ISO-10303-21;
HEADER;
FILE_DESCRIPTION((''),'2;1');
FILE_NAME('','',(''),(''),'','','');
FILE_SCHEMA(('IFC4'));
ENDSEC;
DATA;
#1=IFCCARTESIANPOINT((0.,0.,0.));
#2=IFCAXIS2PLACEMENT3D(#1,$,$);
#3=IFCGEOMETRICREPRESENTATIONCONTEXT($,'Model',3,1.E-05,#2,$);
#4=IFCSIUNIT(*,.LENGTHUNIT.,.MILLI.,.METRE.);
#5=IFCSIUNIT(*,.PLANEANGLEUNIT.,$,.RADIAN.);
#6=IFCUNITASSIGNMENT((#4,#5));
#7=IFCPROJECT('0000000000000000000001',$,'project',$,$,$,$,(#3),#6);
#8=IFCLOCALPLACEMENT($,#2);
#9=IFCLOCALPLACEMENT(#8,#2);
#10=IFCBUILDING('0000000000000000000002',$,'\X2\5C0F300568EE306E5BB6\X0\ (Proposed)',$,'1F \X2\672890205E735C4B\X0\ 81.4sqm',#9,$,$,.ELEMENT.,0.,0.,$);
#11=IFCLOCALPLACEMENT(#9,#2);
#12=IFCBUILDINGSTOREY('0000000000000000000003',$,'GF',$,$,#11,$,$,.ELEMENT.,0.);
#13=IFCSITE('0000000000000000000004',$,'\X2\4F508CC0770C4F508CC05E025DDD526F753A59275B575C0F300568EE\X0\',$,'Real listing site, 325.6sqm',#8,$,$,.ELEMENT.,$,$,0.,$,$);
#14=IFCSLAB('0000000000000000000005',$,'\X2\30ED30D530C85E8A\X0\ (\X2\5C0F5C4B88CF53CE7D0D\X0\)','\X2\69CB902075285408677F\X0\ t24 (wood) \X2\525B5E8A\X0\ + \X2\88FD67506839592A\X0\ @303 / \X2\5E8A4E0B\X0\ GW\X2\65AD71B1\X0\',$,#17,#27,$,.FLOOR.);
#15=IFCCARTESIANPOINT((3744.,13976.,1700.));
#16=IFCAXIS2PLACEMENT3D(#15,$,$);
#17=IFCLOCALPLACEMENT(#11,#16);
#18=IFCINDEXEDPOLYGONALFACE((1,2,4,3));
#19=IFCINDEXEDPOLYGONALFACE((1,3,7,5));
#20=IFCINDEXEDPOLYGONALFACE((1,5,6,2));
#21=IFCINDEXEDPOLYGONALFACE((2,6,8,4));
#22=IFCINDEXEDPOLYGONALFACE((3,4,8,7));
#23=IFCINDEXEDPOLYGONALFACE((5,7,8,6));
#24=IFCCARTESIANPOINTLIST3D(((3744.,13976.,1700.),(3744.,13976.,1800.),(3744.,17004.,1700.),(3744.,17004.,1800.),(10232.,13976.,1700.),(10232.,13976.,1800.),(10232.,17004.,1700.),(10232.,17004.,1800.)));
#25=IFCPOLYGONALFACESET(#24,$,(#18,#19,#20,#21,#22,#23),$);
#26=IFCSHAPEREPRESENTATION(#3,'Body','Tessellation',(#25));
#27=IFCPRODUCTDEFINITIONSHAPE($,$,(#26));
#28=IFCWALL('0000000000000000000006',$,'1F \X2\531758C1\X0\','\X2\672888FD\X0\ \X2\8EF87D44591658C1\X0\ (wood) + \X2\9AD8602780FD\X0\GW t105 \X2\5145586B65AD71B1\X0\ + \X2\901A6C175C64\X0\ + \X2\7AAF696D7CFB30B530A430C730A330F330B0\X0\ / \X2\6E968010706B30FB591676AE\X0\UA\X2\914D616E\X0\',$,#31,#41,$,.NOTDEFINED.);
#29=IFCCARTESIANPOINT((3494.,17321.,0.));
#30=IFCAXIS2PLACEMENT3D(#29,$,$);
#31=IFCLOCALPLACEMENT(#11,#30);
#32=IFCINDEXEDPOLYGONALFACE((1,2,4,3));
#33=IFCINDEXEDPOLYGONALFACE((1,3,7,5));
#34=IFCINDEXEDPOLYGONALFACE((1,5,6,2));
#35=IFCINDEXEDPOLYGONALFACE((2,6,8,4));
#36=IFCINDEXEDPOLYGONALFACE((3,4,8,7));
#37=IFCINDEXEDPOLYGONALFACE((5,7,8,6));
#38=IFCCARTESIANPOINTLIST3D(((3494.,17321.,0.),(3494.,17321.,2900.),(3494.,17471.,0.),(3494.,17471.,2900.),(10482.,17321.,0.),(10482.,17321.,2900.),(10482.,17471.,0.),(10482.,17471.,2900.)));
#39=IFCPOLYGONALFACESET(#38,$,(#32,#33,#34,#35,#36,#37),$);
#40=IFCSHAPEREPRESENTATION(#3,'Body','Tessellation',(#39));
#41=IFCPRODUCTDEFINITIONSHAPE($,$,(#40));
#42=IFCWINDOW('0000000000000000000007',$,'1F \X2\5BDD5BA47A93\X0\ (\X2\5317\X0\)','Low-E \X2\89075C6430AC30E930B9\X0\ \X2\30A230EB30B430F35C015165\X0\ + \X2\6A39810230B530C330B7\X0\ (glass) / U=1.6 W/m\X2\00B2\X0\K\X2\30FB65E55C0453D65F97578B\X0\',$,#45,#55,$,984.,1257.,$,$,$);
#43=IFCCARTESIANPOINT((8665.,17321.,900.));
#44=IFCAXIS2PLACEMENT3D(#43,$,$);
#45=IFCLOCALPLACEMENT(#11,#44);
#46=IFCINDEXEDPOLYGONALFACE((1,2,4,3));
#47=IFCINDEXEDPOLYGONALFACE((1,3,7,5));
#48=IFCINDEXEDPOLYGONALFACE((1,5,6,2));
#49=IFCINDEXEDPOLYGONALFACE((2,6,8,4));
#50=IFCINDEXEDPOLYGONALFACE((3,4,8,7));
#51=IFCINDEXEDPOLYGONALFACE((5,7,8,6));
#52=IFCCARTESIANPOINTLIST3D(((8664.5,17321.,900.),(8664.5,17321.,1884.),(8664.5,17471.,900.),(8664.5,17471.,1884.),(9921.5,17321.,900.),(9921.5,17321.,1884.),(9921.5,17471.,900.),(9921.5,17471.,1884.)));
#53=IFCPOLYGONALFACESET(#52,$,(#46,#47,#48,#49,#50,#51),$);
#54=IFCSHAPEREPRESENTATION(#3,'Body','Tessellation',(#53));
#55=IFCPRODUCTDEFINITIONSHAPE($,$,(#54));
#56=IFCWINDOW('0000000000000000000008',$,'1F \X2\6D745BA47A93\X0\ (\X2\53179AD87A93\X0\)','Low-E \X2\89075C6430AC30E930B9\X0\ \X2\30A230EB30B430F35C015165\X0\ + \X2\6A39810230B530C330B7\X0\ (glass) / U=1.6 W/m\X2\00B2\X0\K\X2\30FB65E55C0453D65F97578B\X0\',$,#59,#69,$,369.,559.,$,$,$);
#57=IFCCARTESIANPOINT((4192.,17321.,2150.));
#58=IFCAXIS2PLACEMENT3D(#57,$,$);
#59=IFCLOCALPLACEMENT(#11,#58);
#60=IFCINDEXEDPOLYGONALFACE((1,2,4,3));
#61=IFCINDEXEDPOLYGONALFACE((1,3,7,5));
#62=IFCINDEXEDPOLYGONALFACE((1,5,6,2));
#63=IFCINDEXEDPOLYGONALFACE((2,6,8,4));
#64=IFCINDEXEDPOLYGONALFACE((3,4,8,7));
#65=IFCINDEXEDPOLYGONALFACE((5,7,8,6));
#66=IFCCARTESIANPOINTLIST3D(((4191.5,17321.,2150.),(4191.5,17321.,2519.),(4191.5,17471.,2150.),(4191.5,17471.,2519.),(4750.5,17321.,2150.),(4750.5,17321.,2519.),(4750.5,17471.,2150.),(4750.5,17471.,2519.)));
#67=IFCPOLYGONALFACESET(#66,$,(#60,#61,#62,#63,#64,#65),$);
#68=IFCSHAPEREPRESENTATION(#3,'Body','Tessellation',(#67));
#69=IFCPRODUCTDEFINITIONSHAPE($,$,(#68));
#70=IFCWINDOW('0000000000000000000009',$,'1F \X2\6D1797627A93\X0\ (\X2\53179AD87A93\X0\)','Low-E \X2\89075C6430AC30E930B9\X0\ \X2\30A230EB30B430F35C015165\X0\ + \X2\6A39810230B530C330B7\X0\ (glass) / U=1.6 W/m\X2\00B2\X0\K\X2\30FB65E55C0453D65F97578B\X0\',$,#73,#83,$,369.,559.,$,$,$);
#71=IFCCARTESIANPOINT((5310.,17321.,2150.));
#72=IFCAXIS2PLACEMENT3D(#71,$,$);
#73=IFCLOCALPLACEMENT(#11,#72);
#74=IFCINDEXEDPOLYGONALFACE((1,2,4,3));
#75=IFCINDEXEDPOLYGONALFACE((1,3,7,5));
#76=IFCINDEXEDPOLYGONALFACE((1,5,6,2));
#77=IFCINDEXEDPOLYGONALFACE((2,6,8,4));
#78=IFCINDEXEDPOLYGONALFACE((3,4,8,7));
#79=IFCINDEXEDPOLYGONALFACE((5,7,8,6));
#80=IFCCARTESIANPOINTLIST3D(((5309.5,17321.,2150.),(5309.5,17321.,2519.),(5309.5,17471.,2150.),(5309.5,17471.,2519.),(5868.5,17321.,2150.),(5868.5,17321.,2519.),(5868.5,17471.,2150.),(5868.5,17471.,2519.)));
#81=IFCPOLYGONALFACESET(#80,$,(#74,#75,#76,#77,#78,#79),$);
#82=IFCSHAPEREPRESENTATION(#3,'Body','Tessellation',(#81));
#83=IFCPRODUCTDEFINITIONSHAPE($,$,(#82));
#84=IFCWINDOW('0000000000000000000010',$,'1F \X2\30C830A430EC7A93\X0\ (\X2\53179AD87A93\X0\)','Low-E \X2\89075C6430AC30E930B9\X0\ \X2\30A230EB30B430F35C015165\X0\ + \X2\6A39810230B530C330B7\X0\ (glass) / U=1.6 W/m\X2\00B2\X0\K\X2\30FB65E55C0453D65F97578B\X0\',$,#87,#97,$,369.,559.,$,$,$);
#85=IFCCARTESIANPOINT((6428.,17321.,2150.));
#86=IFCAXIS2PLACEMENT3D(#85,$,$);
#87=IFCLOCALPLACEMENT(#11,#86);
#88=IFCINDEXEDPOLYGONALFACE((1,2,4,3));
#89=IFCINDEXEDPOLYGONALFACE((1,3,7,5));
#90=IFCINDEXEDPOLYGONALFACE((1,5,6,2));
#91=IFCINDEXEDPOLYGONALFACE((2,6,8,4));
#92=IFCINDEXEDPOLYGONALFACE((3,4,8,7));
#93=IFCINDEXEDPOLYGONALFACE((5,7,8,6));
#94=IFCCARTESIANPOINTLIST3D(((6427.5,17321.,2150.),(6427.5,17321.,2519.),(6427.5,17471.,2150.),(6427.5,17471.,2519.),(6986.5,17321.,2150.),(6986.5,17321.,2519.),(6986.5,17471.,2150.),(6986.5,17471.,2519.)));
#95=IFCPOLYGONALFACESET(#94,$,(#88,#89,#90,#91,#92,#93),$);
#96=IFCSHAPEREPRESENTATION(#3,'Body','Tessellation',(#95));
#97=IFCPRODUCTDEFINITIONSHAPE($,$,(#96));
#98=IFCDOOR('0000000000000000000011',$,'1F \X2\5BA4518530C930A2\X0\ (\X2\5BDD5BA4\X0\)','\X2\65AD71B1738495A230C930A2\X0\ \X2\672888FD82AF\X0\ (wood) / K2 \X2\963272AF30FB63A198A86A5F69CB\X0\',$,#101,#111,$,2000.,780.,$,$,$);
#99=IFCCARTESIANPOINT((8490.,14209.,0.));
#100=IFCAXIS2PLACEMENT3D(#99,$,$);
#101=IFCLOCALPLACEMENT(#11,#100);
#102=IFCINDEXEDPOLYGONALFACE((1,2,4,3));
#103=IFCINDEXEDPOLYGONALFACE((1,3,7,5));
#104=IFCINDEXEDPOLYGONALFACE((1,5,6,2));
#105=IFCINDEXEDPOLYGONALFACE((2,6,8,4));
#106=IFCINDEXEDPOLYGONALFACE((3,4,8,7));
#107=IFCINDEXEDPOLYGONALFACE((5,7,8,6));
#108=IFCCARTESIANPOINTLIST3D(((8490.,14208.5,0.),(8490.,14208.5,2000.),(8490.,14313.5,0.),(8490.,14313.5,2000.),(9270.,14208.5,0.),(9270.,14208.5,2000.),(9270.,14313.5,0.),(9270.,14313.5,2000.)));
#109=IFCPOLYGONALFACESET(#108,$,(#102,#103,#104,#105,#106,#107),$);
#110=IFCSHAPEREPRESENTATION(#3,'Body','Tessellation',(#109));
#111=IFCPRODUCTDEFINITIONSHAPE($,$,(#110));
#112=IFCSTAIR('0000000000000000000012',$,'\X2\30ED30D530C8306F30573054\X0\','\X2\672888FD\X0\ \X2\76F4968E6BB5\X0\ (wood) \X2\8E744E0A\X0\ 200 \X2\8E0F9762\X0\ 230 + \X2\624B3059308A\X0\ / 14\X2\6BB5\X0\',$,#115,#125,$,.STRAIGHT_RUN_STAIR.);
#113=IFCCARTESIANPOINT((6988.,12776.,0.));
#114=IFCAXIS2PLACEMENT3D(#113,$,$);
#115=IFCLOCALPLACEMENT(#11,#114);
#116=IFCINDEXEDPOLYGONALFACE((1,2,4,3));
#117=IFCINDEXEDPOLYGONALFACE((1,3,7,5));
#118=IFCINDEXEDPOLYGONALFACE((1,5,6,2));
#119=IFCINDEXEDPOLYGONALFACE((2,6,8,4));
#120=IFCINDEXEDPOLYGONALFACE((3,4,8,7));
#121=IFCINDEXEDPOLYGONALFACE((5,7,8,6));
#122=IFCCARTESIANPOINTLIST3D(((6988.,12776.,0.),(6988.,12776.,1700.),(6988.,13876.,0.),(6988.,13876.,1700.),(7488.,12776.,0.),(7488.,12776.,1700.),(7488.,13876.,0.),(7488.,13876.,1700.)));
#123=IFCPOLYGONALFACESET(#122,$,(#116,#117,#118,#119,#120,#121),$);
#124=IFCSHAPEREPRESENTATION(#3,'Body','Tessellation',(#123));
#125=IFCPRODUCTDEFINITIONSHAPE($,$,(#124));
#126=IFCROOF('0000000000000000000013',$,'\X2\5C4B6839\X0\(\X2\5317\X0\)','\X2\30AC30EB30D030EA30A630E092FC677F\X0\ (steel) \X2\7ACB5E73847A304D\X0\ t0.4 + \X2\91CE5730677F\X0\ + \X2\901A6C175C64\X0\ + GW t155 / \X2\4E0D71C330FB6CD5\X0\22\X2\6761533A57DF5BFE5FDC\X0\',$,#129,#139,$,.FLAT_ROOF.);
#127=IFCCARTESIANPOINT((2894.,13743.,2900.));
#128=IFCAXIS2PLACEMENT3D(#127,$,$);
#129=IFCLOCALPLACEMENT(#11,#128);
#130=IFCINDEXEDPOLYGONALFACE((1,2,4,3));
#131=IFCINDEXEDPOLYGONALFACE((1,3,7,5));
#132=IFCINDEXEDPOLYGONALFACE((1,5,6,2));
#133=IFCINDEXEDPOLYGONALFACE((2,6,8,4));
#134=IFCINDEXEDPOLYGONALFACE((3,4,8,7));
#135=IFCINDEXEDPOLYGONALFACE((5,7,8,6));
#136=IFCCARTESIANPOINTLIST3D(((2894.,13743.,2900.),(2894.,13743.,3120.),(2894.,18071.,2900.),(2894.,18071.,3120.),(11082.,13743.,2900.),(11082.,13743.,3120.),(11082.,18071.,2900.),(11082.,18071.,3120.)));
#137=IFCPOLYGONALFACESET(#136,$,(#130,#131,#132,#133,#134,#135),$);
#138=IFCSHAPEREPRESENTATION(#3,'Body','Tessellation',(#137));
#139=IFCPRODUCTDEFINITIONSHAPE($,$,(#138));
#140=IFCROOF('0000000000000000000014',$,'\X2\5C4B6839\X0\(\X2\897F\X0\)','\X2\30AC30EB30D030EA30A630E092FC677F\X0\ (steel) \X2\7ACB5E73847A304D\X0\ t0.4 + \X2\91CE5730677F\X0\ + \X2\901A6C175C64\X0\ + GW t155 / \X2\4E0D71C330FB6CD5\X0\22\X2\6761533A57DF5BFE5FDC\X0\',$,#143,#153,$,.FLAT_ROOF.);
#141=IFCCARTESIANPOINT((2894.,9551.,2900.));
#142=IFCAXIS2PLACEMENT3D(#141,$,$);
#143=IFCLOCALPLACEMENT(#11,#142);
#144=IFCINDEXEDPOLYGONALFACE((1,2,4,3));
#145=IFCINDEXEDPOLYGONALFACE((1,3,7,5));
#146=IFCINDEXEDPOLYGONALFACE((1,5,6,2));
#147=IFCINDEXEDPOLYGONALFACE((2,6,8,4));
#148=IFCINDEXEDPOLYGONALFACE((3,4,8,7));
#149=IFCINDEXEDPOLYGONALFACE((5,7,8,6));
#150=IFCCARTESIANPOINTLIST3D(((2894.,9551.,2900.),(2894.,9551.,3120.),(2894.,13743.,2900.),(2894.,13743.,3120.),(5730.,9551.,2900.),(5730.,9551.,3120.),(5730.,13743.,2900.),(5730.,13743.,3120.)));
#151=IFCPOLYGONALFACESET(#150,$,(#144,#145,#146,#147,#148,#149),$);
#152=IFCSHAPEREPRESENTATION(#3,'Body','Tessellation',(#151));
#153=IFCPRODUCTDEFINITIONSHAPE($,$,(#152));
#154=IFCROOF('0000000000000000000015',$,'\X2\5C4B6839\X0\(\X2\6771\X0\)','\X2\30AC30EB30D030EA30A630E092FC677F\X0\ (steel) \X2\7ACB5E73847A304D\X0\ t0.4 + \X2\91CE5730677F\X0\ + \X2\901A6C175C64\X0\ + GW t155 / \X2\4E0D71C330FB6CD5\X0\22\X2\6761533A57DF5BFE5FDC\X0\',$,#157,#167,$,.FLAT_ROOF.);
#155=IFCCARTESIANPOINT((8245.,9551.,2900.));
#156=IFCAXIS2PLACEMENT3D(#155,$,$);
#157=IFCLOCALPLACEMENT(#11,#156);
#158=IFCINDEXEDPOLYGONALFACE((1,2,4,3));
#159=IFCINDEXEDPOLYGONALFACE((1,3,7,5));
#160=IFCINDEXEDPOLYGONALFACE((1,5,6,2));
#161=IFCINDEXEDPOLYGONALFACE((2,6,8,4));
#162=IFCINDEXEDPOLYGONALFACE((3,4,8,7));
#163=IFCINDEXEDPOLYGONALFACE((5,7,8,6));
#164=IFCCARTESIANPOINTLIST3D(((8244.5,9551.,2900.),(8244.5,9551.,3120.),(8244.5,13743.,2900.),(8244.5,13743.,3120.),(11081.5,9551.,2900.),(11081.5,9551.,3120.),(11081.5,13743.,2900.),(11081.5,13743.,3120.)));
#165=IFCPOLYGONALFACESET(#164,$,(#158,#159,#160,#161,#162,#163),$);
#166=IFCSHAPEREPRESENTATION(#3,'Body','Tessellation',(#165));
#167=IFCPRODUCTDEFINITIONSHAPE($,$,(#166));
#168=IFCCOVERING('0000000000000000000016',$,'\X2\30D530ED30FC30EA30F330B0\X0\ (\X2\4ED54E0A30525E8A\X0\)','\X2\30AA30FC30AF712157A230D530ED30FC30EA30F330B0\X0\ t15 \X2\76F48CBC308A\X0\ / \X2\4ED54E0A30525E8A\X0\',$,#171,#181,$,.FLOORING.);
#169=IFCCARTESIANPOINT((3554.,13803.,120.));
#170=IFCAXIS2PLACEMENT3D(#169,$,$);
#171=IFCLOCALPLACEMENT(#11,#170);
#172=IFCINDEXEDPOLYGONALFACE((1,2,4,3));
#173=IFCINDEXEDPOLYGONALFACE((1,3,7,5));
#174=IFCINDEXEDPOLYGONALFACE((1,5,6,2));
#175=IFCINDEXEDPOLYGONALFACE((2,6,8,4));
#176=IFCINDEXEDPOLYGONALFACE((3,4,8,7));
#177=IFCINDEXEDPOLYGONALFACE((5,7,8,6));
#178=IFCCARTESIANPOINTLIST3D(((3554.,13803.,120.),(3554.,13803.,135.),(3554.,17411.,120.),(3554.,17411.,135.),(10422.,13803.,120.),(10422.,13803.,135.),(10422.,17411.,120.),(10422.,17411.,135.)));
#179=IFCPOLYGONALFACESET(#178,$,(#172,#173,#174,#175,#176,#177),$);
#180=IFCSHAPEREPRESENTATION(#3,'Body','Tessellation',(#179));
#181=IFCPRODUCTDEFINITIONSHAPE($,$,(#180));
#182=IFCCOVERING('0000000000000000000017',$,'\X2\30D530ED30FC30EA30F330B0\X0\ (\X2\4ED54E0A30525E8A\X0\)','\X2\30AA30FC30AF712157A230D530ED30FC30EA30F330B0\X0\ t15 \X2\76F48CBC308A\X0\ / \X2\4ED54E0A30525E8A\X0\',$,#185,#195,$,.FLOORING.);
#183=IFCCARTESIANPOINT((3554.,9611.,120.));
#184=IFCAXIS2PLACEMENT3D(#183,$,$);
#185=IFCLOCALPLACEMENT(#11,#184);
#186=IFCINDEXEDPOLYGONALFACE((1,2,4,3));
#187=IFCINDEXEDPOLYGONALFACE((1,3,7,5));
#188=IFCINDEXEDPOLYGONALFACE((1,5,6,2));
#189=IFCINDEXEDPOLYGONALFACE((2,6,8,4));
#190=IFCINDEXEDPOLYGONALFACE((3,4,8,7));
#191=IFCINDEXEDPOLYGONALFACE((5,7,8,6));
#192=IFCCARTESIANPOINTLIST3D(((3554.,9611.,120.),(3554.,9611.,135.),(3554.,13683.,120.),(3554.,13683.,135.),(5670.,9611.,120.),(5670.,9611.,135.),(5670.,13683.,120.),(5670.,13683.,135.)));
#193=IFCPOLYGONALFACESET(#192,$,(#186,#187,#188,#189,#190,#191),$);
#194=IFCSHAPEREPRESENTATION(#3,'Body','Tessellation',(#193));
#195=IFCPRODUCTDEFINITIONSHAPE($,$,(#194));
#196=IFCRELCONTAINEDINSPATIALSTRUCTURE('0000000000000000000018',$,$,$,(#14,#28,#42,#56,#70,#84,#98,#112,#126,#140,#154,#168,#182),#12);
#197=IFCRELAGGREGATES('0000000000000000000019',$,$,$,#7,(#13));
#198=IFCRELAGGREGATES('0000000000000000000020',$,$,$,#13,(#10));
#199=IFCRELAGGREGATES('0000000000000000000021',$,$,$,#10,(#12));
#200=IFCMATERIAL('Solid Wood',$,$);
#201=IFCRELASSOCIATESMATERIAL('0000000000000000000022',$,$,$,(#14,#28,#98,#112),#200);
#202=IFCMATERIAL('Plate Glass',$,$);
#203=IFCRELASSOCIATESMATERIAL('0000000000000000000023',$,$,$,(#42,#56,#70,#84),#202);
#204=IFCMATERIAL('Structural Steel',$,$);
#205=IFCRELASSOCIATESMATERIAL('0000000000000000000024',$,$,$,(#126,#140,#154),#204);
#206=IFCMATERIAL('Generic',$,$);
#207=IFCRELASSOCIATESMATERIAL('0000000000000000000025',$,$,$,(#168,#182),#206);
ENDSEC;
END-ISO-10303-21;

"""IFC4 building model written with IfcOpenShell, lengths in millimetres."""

from ifc_helpers import new_model, si_unit, frame, frame_2d, origin, place, context, project, spatial, rectangle, extrude, material, element, fill, save


model = new_model("IFC4")

# Units and contexts
model_context = context("Model", 3, precision=1e-05, world=origin())
ifc_project = project(units=[si_unit("LENGTHUNIT", "METRE", prefix="MILLI"), si_unit("PLANEANGLEUNIT", "RADIAN")], contexts=[model_context])

# Site, building, storey
site_placement = place(None, origin())
site = spatial("IfcSite", under=ifc_project, at=site_placement, Name="佐賀県佐賀市川副町大字小々森", ObjectType="Real listing site, 325.6sqm", CompositionType="ELEMENT", RefElevation=0.0)
building_placement = place(site_placement, origin())
building = spatial("IfcBuilding", under=site, at=building_placement, Name="小々森の家 (Proposed)", ObjectType="1F 木造平屋 81.4sqm", CompositionType="ELEMENT", ElevationOfRefHeight=0.0, ElevationOfTerrain=0.0)
storey_placement = place(building_placement, origin())
storey = spatial("IfcBuildingStorey", under=building, at=storey_placement, Name="GF", CompositionType="ELEMENT", Elevation=0.0)

# Slab
ifc_material_1 = material(Name="Solid Wood")
slab_1_placement = place(storey_placement, frame((3744.0, 13976.0, 1700.0)))
element("IfcSlab", 1, at=slab_1_placement, inside=storey, material=ifc_material_1, Name="ロフト床 (小屋裏収納)", Description="構造用合板 t24 (wood) 剛床 + 製材根太 @303 / 床下 GW断熱", PredefinedType="FLOOR", context=model_context, shape_type="SweptSolid", body=[
    extrude(rectangle(XDim=6488.0, YDim=3028.0, at=frame_2d((3244.0, 1514.0))), frame((3744.0, 13976.0, 1700.0)), (0.0, 0.0, 1.0), 100.0),
])

# Wall, openings, windows
wall_1_placement = place(storey_placement, frame((3494.0, 17321.0, 0.0)))
wall_1 = element("IfcWall", 2, at=wall_1_placement, inside=storey, material=ifc_material_1, Name="1F 北壁", Description="木製 軸組外壁 (wood) + 高性能GW t105 充填断熱 + 通気層 + 窯業系サイディング / 準耐火・外皮UA配慮", PredefinedType="NOTDEFINED", context=model_context, shape_type="SweptSolid", body=[
    extrude(rectangle(XDim=6988.0, YDim=150.0, at=frame_2d((3494.0, 75.0))), frame((3494.0, 17321.0, 0.0)), (0.0, 0.0, 1.0), 2900.0),
])
opening_1_placement = place(storey_placement, frame((8665.0, 17321.0, 900.0)))
opening_1 = element("IfcOpeningElement", 3, at=opening_1_placement, cuts=wall_1, PredefinedType="NOTDEFINED", context=model_context, shape_type="SweptSolid", body=[
    extrude(rectangle(XDim=1257.0, YDim=150.0, at=frame_2d((628.0, 75.0))), frame((8665.0, 17321.0, 900.0)), (0.0, 0.0, 1.0), 984.0),
])
opening_2_placement = place(storey_placement, frame((4192.0, 17321.0, 2150.0)))
opening_2 = element("IfcOpeningElement", 4, at=opening_2_placement, cuts=wall_1, PredefinedType="NOTDEFINED", context=model_context, shape_type="SweptSolid", body=[
    extrude(rectangle(XDim=559.0, YDim=150.0, at=frame_2d((279.0, 75.0))), frame((4192.0, 17321.0, 2150.0)), (0.0, 0.0, 1.0), 369.0),
])
opening_3_placement = place(storey_placement, frame((5310.0, 17321.0, 2150.0)))
opening_3 = element("IfcOpeningElement", 5, at=opening_3_placement, cuts=wall_1, PredefinedType="NOTDEFINED", context=model_context, shape_type="SweptSolid", body=[
    extrude(rectangle(XDim=559.0, YDim=150.0, at=frame_2d((279.0, 75.0))), frame((5310.0, 17321.0, 2150.0)), (0.0, 0.0, 1.0), 369.0),
])
opening_4_placement = place(storey_placement, frame((6428.0, 17321.0, 2150.0)))
opening_4 = element("IfcOpeningElement", 6, at=opening_4_placement, cuts=wall_1, PredefinedType="NOTDEFINED", context=model_context, shape_type="SweptSolid", body=[
    extrude(rectangle(XDim=559.0, YDim=150.0, at=frame_2d((279.0, 75.0))), frame((6428.0, 17321.0, 2150.0)), (0.0, 0.0, 1.0), 369.0),
])
ifc_material_2 = material(Name="Plate Glass")
window_1_placement = place(storey_placement, frame((8665.0, 17321.0, 900.0)))
window_1 = element("IfcWindow", 7, at=window_1_placement, inside=storey, material=ifc_material_2, Name="1F 寝室窓 (北)", Description="Low-E 複層ガラス アルゴン封入 + 樹脂サッシ (glass) / U=1.6 W/m²K・日射取得型", OverallHeight=984.0, OverallWidth=1257.0, context=model_context, shape_type="SweptSolid", body=[
    extrude(rectangle(XDim=1257.0, YDim=150.0, at=frame_2d((628.0, 75.0))), frame((8665.0, 17321.0, 900.0)), (0.0, 0.0, 1.0), 984.0),
])
fill(opening_1, window_1)
window_2_placement = place(storey_placement, frame((4192.0, 17321.0, 2150.0)))
window_2 = element("IfcWindow", 8, at=window_2_placement, inside=storey, material=ifc_material_2, Name="1F 浴室窓 (北高窓)", Description="Low-E 複層ガラス アルゴン封入 + 樹脂サッシ (glass) / U=1.6 W/m²K・日射取得型", OverallHeight=369.0, OverallWidth=559.0, context=model_context, shape_type="SweptSolid", body=[
    extrude(rectangle(XDim=559.0, YDim=150.0, at=frame_2d((279.0, 75.0))), frame((4192.0, 17321.0, 2150.0)), (0.0, 0.0, 1.0), 369.0),
])
fill(opening_2, window_2)
window_3_placement = place(storey_placement, frame((5310.0, 17321.0, 2150.0)))
window_3 = element("IfcWindow", 9, at=window_3_placement, inside=storey, material=ifc_material_2, Name="1F 洗面窓 (北高窓)", Description="Low-E 複層ガラス アルゴン封入 + 樹脂サッシ (glass) / U=1.6 W/m²K・日射取得型", OverallHeight=369.0, OverallWidth=559.0, context=model_context, shape_type="SweptSolid", body=[
    extrude(rectangle(XDim=559.0, YDim=150.0, at=frame_2d((279.0, 75.0))), frame((5310.0, 17321.0, 2150.0)), (0.0, 0.0, 1.0), 369.0),
])
fill(opening_3, window_3)
window_4_placement = place(storey_placement, frame((6428.0, 17321.0, 2150.0)))
window_4 = element("IfcWindow", 10, at=window_4_placement, inside=storey, material=ifc_material_2, Name="1F トイレ窓 (北高窓)", Description="Low-E 複層ガラス アルゴン封入 + 樹脂サッシ (glass) / U=1.6 W/m²K・日射取得型", OverallHeight=369.0, OverallWidth=559.0, context=model_context, shape_type="SweptSolid", body=[
    extrude(rectangle(XDim=559.0, YDim=150.0, at=frame_2d((279.0, 75.0))), frame((6428.0, 17321.0, 2150.0)), (0.0, 0.0, 1.0), 369.0),
])
fill(opening_4, window_4)

# Door
door_1_placement = place(storey_placement, frame((8490.0, 14209.0, 0.0)))
element("IfcDoor", 11, at=door_1_placement, inside=storey, material=ifc_material_1, Name="1F 室内ドア (寝室)", Description="断熱玄関ドア 木製芯 (wood) / K2 防犯・採風機構", OverallHeight=2000.0, OverallWidth=780.0, context=model_context, shape_type="SweptSolid", body=[
    extrude(rectangle(XDim=780.0, YDim=105.0, at=frame_2d((390.0, 52.0))), frame((8490.0, 14209.0, 0.0)), (0.0, 0.0, 1.0), 2000.0),
])

# Stair
stair_placement = place(storey_placement, frame((6988.0, 12776.0, 0.0)))
element("IfcStair", 12, at=stair_placement, inside=storey, material=ifc_material_1, Name="ロフトはしご", Description="木製 直階段 (wood) 蹴上 200 踏面 230 + 手すり / 14段", PredefinedType="STRAIGHT_RUN_STAIR", context=model_context, shape_type="SweptSolid", body=[
    extrude(rectangle(XDim=500.0, YDim=1100.0, at=frame_2d((250.0, 550.0))), frame((6988.0, 12776.0, 0.0)), (0.0, 0.0, 1.0), 1700.0),
])

# Roofs
ifc_material_3 = material(Name="Structural Steel")
roof_1_placement = place(storey_placement, frame((2894.0, 13743.0, 2900.0)))
element("IfcRoof", 13, at=roof_1_placement, inside=storey, material=ifc_material_3, Name="屋根(北)", Description="ガルバリウム鋼板 (steel) 立平葺き t0.4 + 野地板 + 通気層 + GW t155 / 不燃・法22条区域対応", PredefinedType="FLAT_ROOF", context=model_context, shape_type="SweptSolid", body=[
    extrude(rectangle(XDim=8188.0, YDim=4328.0, at=frame_2d((4094.0, 2164.0))), frame((2894.0, 13743.0, 2900.0)), (0.0, 0.0, 1.0), 220.0),
])
roof_2_placement = place(storey_placement, frame((2894.0, 9551.0, 2900.0)))
element("IfcRoof", 14, at=roof_2_placement, inside=storey, material=ifc_material_3, Name="屋根(西)", Description="ガルバリウム鋼板 (steel) 立平葺き t0.4 + 野地板 + 通気層 + GW t155 / 不燃・法22条区域対応", PredefinedType="FLAT_ROOF", context=model_context, shape_type="SweptSolid", body=[
    extrude(rectangle(XDim=2836.0, YDim=4192.0, at=frame_2d((1418.0, 2096.0))), frame((2894.0, 9551.0, 2900.0)), (0.0, 0.0, 1.0), 220.0),
])
roof_3_placement = place(storey_placement, frame((8245.0, 9551.0, 2900.0)))
element("IfcRoof", 15, at=roof_3_placement, inside=storey, material=ifc_material_3, Name="屋根(東)", Description="ガルバリウム鋼板 (steel) 立平葺き t0.4 + 野地板 + 通気層 + GW t155 / 不燃・法22条区域対応", PredefinedType="FLAT_ROOF", context=model_context, shape_type="SweptSolid", body=[
    extrude(rectangle(XDim=2837.0, YDim=4192.0, at=frame_2d((1418.0, 2096.0))), frame((8245.0, 9551.0, 2900.0)), (0.0, 0.0, 1.0), 220.0),
])

# Coverings
ifc_material_4 = material(Name="Generic")
covering_1_placement = place(storey_placement, frame((3554.0, 13803.0, 120.0)))
element("IfcCovering", 16, at=covering_1_placement, inside=storey, material=ifc_material_4, Name="フローリング (仕上げ床)", Description="オーク無垢フローリング t15 直貼り / 仕上げ床", PredefinedType="FLOORING", context=model_context, shape_type="SweptSolid", body=[
    extrude(rectangle(XDim=6868.0, YDim=3608.0, at=frame_2d((3434.0, 1804.0))), frame((3554.0, 13803.0, 120.0)), (0.0, 0.0, 1.0), 15.0),
])
covering_2_placement = place(storey_placement, frame((3554.0, 9611.0, 120.0)))
element("IfcCovering", 17, at=covering_2_placement, inside=storey, material=ifc_material_4, Name="フローリング (仕上げ床)", Description="オーク無垢フローリング t15 直貼り / 仕上げ床", PredefinedType="FLOORING", context=model_context, shape_type="SweptSolid", body=[
    extrude(rectangle(XDim=2116.0, YDim=4072.0, at=frame_2d((1058.0, 2036.0))), frame((3554.0, 9611.0, 120.0)), (0.0, 0.0, 1.0), 15.0),
])

save(model, "model.ifc")
